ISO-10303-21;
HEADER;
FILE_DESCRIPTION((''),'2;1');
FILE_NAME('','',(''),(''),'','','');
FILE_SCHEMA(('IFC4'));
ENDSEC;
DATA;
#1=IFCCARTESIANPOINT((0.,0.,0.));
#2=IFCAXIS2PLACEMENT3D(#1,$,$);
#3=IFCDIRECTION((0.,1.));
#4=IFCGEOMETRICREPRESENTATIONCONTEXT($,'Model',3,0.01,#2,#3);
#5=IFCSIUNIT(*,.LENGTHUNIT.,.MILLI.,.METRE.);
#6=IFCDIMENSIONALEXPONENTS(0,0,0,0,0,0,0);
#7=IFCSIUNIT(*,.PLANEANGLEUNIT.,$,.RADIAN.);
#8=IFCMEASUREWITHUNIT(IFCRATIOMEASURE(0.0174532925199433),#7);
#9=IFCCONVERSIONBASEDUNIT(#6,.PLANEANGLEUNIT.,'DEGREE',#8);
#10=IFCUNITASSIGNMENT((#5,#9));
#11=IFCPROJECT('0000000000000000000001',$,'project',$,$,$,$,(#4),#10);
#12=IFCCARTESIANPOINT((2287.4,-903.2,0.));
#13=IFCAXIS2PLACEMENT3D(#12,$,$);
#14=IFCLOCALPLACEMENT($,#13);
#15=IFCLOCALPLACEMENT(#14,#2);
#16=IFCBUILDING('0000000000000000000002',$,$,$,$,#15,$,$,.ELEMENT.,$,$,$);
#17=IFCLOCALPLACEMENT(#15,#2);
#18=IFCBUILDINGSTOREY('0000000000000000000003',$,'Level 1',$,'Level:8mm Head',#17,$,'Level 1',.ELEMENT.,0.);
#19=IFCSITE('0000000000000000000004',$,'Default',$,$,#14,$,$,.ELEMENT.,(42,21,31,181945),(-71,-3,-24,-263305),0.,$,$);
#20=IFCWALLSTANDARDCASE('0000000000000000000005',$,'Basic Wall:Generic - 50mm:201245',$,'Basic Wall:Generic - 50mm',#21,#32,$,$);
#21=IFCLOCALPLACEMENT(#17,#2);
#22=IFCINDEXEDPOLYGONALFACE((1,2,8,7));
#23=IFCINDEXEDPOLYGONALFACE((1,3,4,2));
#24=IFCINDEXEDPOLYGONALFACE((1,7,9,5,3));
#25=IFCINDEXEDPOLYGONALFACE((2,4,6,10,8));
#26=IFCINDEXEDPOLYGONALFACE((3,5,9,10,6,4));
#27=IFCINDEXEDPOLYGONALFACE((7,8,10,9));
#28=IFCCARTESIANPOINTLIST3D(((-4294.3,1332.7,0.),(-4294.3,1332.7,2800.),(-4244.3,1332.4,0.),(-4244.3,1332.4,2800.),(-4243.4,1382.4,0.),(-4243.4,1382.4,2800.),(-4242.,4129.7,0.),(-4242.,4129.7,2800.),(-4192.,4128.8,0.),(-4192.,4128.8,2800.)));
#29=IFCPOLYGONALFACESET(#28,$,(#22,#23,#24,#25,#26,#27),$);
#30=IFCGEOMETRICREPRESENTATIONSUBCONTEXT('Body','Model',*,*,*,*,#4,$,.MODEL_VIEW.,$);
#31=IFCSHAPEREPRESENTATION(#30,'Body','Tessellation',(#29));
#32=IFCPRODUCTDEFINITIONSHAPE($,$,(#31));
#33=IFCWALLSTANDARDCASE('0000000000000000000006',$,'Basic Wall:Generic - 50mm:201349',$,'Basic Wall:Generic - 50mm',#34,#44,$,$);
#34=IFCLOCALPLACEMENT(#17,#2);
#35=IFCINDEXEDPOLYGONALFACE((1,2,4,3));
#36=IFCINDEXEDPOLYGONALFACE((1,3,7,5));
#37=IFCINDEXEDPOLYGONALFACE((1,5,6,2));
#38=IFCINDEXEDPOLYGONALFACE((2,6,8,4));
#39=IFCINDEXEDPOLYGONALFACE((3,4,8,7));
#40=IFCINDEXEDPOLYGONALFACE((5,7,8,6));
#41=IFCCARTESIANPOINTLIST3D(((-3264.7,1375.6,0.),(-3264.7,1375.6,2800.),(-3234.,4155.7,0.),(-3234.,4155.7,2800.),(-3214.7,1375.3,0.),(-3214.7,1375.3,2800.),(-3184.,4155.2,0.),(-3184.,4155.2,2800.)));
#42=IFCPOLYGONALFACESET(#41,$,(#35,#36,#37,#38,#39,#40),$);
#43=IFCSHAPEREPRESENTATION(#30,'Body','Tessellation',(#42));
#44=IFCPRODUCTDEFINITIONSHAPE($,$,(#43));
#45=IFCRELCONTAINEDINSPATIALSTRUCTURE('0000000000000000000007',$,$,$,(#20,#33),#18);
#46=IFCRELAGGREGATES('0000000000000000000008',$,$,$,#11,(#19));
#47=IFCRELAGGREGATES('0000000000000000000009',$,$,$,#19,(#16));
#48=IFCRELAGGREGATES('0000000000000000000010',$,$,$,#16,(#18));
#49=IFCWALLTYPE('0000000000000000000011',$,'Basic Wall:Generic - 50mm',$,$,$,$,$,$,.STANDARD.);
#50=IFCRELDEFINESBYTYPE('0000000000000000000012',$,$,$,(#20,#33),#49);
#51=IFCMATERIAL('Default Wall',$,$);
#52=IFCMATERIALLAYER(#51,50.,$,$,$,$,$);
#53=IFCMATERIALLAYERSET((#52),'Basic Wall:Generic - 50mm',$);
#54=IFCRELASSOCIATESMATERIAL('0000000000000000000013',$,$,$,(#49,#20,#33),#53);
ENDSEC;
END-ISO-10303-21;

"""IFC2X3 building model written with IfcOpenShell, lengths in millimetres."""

from ifc_helpers import new_model, entity, si_unit, converted_unit, direction, frame, origin, place, context, subcontext, project, spatial, polyline, outline, extrude, material, layer, layer_set, layer_usage, type_object, element, save


model = new_model("IFC2X3")

# Units and contexts
model_context = context("Model", 3, precision=0.01, world=origin(), true_north=direction((0.0, 1.0)))
body_context = subcontext(model_context, "Body", "Model", "MODEL_VIEW")
ifc_project = project(units=[si_unit("LENGTHUNIT", "METRE", prefix="MILLI"), converted_unit("PLANEANGLEUNIT", "DEGREE", entity("IfcRatioMeasure", 0.0174532925199433), si_unit("PLANEANGLEUNIT", "RADIAN"), dimensions=[0, 0, 0, 0, 0, 0, 0])], contexts=[model_context])

# Site, building, storey
site_placement = place(None, frame((2287.4, -903.2, 0.0)))
site = spatial("IfcSite", under=ifc_project, at=site_placement, Name="Default", CompositionType="ELEMENT", RefLatitude=(42, 21, 31, 181945), RefLongitude=(-71, -3, -24, -263305), RefElevation=0.0)
building_placement = place(site_placement, origin())
building = spatial("IfcBuilding", under=site, at=building_placement, CompositionType="ELEMENT")
storey_placement = place(building_placement, origin())
storey = spatial("IfcBuildingStorey", under=building, at=storey_placement, Name="Level 1", ObjectType="Level:8mm Head", LongName="Level 1", CompositionType="ELEMENT", Elevation=0.0)

# Walls
ifc_material_1 = material(Name="Default Wall")
ifc_layer_1 = layer(ifc_material_1, 50.0)
ifc_layer_set_1 = layer_set([ifc_layer_1], Name="Basic Wall:Generic - 50mm")
ifc_layer_usage_1 = layer_usage(ifc_layer_set_1, "AXIS2", "POSITIVE", -25.0)
wall_type_1 = type_object("IfcWallType", Name="Basic Wall:Generic - 50mm", PredefinedType="STANDARD", material=ifc_layer_set_1)
wall_1_placement = place(storey_placement, frame((-4217.0, 4129.3, 0.0), z_axis=(0.0, 0.0, 1.0), x_axis=(-0.018701, -0.999825, 0.0)))
element("IfcWallStandardCase", 1, at=wall_1_placement, inside=storey, type_object=wall_type_1, material=ifc_layer_usage_1, Name="Basic Wall:Generic - 50mm:201245", ObjectType="Basic Wall:Generic - 50mm", context=body_context, shape_type="SweptSolid", body=[
    extrude(outline(polyline([(2797.5, -25.0), (2796.9, 25.0), (2746.9, 25.0), (0.0, 25.0), (0.0, -25.0), (2797.5, -25.0)])), origin(), (0.0, 0.0, 1.0), 2800.0),
])
ifc_layer_usage_2 = layer_usage(ifc_layer_set_1, "AXIS2", "POSITIVE", -25.0)
wall_2_placement = place(storey_placement, frame((-3239.7, 1375.4, 0.0), z_axis=(0.0, 0.0, 1.0), x_axis=(0.011026, 0.999939, 0.0)))
element("IfcWallStandardCase", 2, at=wall_2_placement, inside=storey, type_object=wall_type_1, material=ifc_layer_usage_2, Name="Basic Wall:Generic - 50mm:201349", ObjectType="Basic Wall:Generic - 50mm", context=body_context, shape_type="SweptSolid", body=[
    extrude(outline(polyline([(2780.2, -25.0), (2780.2, 25.0), (0.0, 25.0), (0.2, -25.0), (2780.2, -25.0)])), origin(), (0.0, 0.0, 1.0), 2800.0),
])

save(model, "model.ifc")
